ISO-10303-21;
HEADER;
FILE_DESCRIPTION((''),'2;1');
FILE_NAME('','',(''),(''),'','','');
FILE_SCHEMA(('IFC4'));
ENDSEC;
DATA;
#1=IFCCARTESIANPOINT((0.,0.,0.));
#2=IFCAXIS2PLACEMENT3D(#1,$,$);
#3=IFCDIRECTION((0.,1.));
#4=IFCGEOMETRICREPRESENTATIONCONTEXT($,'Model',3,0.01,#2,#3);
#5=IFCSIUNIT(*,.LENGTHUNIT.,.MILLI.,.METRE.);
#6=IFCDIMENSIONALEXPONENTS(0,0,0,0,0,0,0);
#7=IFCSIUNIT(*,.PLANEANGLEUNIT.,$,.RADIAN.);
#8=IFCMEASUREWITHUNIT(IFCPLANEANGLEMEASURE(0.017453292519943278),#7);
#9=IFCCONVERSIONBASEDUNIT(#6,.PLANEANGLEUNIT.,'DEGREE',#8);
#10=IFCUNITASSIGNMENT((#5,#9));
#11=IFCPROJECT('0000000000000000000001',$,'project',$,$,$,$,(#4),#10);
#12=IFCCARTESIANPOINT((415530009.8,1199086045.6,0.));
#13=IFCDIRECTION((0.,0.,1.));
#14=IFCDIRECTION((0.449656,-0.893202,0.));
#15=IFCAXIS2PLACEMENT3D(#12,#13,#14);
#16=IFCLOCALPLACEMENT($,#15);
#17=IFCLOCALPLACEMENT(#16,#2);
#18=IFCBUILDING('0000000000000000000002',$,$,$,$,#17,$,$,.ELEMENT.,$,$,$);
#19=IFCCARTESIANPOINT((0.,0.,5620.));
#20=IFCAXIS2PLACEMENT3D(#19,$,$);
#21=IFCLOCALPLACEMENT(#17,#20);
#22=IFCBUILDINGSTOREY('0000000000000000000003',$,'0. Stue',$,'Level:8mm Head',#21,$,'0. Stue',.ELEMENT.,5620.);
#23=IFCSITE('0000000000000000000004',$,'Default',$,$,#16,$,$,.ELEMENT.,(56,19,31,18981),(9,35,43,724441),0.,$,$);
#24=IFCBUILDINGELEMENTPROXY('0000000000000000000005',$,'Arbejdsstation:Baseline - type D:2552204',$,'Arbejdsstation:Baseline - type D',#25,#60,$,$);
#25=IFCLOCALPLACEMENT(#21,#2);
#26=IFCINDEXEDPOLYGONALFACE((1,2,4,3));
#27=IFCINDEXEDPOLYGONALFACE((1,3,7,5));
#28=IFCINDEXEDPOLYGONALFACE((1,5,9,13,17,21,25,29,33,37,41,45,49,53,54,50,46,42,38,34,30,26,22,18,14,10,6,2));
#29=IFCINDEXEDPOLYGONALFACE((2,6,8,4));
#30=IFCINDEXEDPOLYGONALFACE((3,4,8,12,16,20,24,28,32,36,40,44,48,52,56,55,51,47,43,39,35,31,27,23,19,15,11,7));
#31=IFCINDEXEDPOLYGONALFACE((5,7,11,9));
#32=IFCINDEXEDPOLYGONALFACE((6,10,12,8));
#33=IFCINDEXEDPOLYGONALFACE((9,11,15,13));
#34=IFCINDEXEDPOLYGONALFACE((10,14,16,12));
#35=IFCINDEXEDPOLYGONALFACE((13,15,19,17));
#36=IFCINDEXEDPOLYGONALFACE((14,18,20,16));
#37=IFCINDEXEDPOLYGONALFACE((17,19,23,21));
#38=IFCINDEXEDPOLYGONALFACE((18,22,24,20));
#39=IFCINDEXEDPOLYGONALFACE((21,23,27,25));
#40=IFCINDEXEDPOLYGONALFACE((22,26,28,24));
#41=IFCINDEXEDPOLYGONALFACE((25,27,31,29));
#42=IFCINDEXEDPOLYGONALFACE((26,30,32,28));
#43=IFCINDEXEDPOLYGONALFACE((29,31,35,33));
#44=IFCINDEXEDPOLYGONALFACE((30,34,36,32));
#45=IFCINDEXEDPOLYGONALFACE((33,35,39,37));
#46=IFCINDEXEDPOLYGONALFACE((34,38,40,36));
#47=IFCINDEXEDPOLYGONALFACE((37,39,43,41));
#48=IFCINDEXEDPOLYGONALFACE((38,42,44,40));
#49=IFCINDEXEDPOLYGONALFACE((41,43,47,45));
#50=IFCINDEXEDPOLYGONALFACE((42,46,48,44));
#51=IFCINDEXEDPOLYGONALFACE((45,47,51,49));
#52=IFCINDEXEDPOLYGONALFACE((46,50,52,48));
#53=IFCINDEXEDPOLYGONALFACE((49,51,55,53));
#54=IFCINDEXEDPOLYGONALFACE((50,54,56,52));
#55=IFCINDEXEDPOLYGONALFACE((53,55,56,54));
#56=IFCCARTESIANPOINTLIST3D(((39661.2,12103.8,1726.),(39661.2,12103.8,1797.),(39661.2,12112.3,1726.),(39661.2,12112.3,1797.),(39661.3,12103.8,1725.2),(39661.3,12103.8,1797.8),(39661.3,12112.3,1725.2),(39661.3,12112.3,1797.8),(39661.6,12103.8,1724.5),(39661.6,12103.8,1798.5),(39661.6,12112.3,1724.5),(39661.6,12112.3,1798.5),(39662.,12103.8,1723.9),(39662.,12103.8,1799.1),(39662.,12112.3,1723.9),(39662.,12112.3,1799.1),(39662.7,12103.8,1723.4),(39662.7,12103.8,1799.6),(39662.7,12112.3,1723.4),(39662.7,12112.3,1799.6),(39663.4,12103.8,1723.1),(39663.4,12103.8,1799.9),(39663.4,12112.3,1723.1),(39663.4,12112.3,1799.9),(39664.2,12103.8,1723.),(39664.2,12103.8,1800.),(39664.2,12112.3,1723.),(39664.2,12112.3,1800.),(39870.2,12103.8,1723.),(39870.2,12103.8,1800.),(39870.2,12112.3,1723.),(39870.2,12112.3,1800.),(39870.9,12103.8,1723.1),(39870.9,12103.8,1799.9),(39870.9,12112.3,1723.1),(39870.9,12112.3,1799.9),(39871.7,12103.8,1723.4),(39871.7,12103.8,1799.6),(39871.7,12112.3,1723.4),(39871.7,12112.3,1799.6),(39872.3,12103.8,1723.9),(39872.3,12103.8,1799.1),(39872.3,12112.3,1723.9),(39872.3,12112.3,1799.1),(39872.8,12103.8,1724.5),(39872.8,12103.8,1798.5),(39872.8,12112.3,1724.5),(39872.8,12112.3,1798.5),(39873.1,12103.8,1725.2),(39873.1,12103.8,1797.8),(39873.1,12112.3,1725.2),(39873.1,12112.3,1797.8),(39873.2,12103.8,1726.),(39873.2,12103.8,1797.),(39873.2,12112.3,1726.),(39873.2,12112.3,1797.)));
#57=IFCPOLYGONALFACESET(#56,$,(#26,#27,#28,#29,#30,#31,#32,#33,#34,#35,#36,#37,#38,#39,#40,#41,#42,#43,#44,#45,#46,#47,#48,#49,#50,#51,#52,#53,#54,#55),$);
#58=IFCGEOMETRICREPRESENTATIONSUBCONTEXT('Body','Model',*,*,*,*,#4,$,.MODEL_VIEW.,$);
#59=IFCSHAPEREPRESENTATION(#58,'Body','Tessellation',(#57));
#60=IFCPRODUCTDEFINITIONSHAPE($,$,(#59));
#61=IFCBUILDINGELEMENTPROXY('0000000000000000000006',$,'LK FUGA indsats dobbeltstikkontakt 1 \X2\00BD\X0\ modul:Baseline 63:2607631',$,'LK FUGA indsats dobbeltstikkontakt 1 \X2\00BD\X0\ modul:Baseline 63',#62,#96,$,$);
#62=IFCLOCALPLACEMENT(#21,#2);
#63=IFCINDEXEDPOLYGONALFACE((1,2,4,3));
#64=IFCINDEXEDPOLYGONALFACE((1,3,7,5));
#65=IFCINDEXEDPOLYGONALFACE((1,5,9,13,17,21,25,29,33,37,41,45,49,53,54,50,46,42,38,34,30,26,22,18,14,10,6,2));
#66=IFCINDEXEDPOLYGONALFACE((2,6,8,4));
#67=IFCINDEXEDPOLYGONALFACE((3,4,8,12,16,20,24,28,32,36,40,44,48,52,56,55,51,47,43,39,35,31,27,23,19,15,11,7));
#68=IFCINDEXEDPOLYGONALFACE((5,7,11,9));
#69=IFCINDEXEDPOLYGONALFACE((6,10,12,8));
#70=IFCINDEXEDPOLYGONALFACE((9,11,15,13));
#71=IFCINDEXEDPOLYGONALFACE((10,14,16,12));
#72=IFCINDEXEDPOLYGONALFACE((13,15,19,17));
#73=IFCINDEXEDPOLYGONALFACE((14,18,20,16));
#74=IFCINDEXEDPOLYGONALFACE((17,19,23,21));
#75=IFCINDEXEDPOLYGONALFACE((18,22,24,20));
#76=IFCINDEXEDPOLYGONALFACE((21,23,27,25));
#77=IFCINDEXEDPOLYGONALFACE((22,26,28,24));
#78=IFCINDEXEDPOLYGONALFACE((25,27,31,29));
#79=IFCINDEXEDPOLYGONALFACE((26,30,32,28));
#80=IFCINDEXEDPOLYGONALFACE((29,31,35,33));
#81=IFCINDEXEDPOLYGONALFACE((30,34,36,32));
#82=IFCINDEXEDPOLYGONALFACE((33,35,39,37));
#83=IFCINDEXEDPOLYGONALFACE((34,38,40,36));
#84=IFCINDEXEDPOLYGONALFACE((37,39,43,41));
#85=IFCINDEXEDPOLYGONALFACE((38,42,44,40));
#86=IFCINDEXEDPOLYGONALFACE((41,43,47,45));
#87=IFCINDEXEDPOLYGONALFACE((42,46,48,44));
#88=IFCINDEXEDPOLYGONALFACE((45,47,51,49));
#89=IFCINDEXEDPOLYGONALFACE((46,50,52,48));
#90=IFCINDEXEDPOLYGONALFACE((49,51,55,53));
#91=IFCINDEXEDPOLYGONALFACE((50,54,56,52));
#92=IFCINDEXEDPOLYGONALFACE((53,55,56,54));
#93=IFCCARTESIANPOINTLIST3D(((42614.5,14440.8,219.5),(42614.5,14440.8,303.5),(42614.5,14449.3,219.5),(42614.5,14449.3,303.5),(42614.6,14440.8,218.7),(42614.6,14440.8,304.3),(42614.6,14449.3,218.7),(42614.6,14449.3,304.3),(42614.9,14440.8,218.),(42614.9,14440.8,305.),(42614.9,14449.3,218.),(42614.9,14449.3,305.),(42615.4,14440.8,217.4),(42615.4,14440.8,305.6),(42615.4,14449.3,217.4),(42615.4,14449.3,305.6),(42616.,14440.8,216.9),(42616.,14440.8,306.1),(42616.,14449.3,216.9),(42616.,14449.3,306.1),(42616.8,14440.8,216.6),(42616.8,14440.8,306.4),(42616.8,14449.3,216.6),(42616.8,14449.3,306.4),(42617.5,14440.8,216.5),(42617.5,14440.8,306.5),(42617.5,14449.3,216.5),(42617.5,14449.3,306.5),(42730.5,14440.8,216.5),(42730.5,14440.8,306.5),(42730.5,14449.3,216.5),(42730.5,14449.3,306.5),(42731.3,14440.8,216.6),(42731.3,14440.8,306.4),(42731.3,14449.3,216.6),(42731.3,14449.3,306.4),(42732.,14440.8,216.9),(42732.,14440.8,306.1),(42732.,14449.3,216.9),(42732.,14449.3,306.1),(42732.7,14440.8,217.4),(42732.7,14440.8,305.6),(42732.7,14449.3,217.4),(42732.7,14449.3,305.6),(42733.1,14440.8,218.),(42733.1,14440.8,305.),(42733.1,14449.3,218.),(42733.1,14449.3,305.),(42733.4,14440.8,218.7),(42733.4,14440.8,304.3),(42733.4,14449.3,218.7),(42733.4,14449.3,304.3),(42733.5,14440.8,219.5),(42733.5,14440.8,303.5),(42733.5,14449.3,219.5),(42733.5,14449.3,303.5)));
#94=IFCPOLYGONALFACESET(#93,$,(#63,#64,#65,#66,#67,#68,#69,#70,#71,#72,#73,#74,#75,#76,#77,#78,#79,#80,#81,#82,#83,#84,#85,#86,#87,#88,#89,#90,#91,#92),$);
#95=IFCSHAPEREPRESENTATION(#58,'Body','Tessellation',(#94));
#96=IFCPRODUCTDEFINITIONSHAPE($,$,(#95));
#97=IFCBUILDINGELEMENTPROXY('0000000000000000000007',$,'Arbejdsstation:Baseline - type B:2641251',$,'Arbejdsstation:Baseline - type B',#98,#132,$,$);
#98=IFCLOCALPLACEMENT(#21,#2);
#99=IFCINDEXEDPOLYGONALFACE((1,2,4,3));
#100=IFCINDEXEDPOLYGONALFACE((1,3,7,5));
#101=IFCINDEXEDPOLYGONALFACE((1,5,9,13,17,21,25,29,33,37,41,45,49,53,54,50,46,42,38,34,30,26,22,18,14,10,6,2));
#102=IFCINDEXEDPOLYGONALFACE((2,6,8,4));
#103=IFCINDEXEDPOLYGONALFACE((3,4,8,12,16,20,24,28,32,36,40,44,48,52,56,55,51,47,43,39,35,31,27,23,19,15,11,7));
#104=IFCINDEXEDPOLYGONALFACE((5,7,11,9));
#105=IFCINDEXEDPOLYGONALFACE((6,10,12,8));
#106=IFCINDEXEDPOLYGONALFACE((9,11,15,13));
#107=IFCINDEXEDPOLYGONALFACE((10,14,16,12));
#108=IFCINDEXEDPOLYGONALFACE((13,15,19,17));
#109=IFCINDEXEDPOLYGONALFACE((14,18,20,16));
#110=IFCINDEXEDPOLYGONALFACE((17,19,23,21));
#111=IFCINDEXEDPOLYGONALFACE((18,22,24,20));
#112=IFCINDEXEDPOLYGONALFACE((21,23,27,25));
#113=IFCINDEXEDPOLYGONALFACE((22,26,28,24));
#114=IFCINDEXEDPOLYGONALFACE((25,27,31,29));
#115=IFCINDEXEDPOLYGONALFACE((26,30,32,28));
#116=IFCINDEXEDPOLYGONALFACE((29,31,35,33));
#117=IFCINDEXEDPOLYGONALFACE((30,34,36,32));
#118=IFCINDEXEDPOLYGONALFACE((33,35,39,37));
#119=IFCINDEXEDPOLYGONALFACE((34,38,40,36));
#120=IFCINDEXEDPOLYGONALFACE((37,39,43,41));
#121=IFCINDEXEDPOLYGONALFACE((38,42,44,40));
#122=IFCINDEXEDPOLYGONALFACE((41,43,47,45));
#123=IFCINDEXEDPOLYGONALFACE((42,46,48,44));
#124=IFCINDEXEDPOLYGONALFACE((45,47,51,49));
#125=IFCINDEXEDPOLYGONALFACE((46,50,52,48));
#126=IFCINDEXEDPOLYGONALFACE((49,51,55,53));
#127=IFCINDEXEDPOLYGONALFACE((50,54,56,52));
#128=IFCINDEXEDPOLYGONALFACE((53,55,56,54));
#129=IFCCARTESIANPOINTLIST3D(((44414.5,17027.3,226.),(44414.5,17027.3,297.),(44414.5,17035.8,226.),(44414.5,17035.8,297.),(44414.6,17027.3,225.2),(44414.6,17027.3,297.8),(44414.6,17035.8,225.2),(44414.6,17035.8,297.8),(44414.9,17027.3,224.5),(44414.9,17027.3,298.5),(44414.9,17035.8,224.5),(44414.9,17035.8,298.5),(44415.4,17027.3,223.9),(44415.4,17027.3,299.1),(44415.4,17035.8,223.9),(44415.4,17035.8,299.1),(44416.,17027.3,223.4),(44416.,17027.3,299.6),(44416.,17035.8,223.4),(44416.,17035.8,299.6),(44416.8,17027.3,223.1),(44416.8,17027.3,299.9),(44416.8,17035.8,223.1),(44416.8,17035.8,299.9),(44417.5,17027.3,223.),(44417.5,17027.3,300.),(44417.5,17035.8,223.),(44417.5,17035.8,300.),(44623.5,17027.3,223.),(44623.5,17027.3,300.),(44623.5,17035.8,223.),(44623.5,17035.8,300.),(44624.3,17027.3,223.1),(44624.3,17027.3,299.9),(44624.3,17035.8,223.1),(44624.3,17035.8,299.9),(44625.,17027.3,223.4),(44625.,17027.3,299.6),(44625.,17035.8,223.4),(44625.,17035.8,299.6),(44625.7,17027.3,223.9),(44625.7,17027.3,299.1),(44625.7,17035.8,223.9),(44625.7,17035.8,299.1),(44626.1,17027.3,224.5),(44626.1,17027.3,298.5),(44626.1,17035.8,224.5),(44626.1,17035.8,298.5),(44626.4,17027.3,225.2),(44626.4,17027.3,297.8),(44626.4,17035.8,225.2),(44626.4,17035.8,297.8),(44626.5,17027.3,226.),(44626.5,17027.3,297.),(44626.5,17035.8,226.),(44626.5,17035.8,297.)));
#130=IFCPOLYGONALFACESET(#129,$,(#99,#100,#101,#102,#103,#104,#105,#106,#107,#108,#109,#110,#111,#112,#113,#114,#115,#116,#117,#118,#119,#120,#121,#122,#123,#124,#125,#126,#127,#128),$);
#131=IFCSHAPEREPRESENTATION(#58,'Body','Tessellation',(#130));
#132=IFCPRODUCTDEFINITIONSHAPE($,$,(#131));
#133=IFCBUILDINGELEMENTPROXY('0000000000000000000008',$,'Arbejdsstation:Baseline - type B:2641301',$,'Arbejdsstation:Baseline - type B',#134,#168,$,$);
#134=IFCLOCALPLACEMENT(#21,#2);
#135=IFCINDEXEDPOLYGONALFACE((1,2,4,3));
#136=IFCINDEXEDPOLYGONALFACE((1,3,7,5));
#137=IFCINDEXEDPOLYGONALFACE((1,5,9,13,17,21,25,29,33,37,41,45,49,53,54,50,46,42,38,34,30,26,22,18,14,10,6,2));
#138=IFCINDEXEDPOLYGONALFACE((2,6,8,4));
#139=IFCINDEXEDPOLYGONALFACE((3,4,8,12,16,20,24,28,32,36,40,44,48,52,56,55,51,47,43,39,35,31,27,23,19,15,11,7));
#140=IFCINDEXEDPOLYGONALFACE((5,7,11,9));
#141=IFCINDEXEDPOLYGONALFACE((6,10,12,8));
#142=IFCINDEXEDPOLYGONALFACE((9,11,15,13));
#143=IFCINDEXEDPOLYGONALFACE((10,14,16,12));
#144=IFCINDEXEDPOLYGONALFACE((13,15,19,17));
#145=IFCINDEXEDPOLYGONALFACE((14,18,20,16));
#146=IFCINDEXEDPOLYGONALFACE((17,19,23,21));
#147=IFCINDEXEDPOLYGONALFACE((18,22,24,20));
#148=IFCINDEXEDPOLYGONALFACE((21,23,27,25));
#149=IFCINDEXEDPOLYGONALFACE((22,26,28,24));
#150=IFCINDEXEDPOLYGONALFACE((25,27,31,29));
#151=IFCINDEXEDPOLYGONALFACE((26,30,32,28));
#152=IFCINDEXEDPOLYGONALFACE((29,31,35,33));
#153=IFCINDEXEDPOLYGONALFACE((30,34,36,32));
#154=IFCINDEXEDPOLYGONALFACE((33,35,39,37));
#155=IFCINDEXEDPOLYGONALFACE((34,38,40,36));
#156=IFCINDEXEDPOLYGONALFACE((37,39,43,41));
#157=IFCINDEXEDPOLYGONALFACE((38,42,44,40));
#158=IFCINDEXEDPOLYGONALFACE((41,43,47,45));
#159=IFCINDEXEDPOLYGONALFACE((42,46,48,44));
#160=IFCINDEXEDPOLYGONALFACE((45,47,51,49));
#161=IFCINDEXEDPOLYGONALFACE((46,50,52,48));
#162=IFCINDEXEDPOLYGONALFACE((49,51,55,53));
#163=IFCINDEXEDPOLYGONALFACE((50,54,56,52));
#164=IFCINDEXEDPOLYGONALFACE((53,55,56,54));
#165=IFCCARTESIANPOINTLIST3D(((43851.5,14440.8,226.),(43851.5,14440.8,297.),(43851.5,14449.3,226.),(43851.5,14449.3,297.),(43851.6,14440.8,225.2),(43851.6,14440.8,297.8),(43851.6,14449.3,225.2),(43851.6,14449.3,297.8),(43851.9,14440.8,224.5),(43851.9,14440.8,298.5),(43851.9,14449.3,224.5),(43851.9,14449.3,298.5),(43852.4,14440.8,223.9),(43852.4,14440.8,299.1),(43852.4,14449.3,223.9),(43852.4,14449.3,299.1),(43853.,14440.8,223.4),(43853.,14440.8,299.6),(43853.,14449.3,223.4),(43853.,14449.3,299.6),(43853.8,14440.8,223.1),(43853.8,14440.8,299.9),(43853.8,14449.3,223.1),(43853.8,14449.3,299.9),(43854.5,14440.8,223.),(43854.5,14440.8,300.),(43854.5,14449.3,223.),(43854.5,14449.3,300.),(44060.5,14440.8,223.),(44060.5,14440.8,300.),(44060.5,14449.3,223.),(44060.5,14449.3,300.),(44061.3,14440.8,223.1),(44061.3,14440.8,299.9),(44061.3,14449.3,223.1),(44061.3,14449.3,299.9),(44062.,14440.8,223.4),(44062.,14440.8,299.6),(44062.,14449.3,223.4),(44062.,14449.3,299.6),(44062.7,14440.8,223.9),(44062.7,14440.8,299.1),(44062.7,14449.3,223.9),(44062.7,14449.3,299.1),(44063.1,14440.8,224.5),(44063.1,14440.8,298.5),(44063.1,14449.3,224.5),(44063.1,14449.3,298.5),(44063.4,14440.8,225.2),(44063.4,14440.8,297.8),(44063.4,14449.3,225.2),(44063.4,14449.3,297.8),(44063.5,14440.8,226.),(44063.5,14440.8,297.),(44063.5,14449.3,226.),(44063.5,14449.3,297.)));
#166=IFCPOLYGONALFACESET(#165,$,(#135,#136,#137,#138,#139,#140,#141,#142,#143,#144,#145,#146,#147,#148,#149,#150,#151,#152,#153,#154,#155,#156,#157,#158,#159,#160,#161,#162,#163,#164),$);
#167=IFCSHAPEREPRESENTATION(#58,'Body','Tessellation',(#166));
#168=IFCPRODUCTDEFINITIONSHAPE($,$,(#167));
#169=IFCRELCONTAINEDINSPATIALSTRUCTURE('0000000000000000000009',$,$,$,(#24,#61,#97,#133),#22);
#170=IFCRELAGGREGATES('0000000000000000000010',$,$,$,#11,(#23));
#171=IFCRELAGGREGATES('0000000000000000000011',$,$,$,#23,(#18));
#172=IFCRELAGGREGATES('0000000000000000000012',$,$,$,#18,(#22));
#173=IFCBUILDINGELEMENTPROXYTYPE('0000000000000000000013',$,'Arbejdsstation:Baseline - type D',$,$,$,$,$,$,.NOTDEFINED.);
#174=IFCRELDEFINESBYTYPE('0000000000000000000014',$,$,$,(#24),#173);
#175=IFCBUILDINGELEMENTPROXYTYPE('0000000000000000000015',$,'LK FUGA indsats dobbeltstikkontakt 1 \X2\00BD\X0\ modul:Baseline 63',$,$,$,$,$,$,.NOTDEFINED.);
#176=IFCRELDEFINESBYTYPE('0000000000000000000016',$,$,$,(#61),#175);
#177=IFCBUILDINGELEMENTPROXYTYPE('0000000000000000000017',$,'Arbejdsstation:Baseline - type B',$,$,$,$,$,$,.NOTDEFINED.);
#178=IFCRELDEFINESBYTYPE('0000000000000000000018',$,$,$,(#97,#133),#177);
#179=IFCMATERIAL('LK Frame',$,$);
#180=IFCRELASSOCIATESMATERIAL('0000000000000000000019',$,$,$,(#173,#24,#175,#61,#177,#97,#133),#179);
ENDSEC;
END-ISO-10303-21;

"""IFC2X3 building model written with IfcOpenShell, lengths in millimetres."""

from ifc_helpers import new_model, entity, si_unit, converted_unit, direction, frame, frame_2d, origin, place, context, subcontext, project, spatial, polyline, circle_curve, parameter, trimmed, segment, composite_curve, outline, extrude, source, transform, mapped, material, type_object, type_shapes, element, save


model = new_model("IFC2X3")

# Units and contexts
model_context = context("Model", 3, precision=0.01, world=origin(), true_north=direction((0.0, 1.0)))
body_context = subcontext(model_context, "Body", "Model", "MODEL_VIEW")
ifc_project = project(units=[si_unit("LENGTHUNIT", "METRE", prefix="MILLI"), converted_unit("PLANEANGLEUNIT", "DEGREE", entity("IfcPlaneAngleMeasure", 0.017453292519943278), si_unit("PLANEANGLEUNIT", "RADIAN"), dimensions=[0, 0, 0, 0, 0, 0, 0])], contexts=[model_context])

# Site, building, storey
site_placement = place(None, frame((415530009.8, 1199086045.6, 0.0), z_axis=(0.0, 0.0, 1.0), x_axis=(0.449656, -0.893202, 0.0)))
site = spatial("IfcSite", under=ifc_project, at=site_placement, Name="Default", CompositionType="ELEMENT", RefLatitude=(56, 19, 31, 18981), RefLongitude=(9, 35, 43, 724441), RefElevation=0.0)
building_placement = place(site_placement, origin())
building = spatial("IfcBuilding", under=site, at=building_placement, CompositionType="ELEMENT")
storey_placement = place(building_placement, frame((0.0, 0.0, 5620.0)))
storey = spatial("IfcBuildingStorey", under=building, at=storey_placement, Name="0. Stue", ObjectType="Level:8mm Head", LongName="0. Stue", CompositionType="ELEMENT", Elevation=5620.0)

# Building element proxies
ifc_material_1 = material(Name="LK Frame")
building_element_proxy_type_1 = type_object("IfcBuildingElementProxyType", Name="Arbejdsstation:Baseline - type D", PredefinedType="NOTDEFINED", material=ifc_material_1)
shared_shape_1 = source(origin(), body_context, "Body", "SweptSolid", [
    extrude(outline(composite_curve([segment(polyline([(-35.5, -106.0), (35.5, -106.0)]), True, "CONTINUOUS"), segment(trimmed(circle_curve(frame_2d((35.5, -103.0), x_axis=(-1.0, 0.0)), 3.0), [parameter(90.0)], [parameter(180.0)], True, "PARAMETER"), True, "CONTINUOUS"), segment(polyline([(38.5, -103.0), (38.5, 103.0)]), True, "CONTINUOUS"), segment(trimmed(circle_curve(frame_2d((35.5, 103.0), x_axis=(-1.0, 0.0)), 3.0), [parameter(180.0)], [parameter(270.0)], True, "PARAMETER"), True, "CONTINUOUS"), segment(polyline([(35.5, 106.0), (-35.5, 106.0)]), True, "CONTINUOUS"), segment(trimmed(circle_curve(frame_2d((-35.5, 103.0), x_axis=(1.0, 0.0)), 3.0), [parameter(90.0)], [parameter(180.0)], True, "PARAMETER"), True, "CONTINUOUS"), segment(polyline([(-38.5, 103.0), (-38.5, -103.0)]), True, "CONTINUOUS"), segment(trimmed(circle_curve(frame_2d((-35.5, -103.0), x_axis=(1.0, 0.0)), 3.0), [parameter(180.0)], [parameter(270.0)], True, "PARAMETER"), True, "CONTINUOUS")], self_intersect=False)), frame((-3.5, -38.5, 0.0), z_axis=(0.0, 0.0, 1.0), x_axis=(0.0, 1.0, 0.0)), (0.0, 0.0, 1.0), 8.5),
])
type_shapes(building_element_proxy_type_1, [shared_shape_1])
proxy_1_placement = place(storey_placement, frame((39763.7, 12103.8, 1800.0), z_axis=(0.0, 1.0, 0.0), x_axis=(-1.0, 0.0, 0.0)))
element("IfcBuildingElementProxy", 1, at=proxy_1_placement, inside=storey, type_object=building_element_proxy_type_1, material=ifc_material_1, Name="Arbejdsstation:Baseline - type D:2552204", ObjectType="Arbejdsstation:Baseline - type D", context=body_context, shape_type="MappedRepresentation", body=[
    mapped(shared_shape_1, transform((0.0, 0.0, 0.0), scale=1.0)),
])
building_element_proxy_type_2 = type_object("IfcBuildingElementProxyType", Name="LK FUGA indsats dobbeltstikkontakt 1 ½ modul:Baseline 63", PredefinedType="NOTDEFINED", material=ifc_material_1)
shared_shape_2 = source(origin(), body_context, "Body", "SweptSolid", [
    extrude(outline(composite_curve([segment(polyline([(-42.0, -59.5), (42.0, -59.5)]), True, "CONTINUOUS"), segment(trimmed(circle_curve(frame_2d((42.0, -56.5), x_axis=(-1.0, 0.0)), 3.0), [parameter(90.0)], [parameter(180.0)], True, "PARAMETER"), True, "CONTINUOUS"), segment(polyline([(45.0, -56.5), (45.0, 56.5)]), True, "CONTINUOUS"), segment(trimmed(circle_curve(frame_2d((42.0, 56.5), x_axis=(-1.0, 0.0)), 3.0), [parameter(180.0)], [parameter(270.0)], True, "PARAMETER"), True, "CONTINUOUS"), segment(polyline([(42.0, 59.5), (-42.0, 59.5)]), True, "CONTINUOUS"), segment(trimmed(circle_curve(frame_2d((-42.0, 56.5), x_axis=(1.0, 0.0)), 3.0), [parameter(90.0)], [parameter(180.0)], True, "PARAMETER"), True, "CONTINUOUS"), segment(polyline([(-45.0, 56.5), (-45.0, -56.5)]), True, "CONTINUOUS"), segment(trimmed(circle_curve(frame_2d((-42.0, -56.5), x_axis=(1.0, 0.0)), 3.0), [parameter(180.0)], [parameter(270.0)], True, "PARAMETER"), True, "CONTINUOUS")], self_intersect=False)), frame((0.0, -38.5, 0.0), z_axis=(0.0, 0.0, 1.0), x_axis=(0.0, 1.0, 0.0)), (0.0, 0.0, 1.0), 8.5),
])
type_shapes(building_element_proxy_type_2, [shared_shape_2])
proxy_2_placement = place(storey_placement, frame((42674.0, 14440.8, 300.0), z_axis=(0.0, 1.0, 0.0), x_axis=(-1.0, 0.0, 0.0)))
element("IfcBuildingElementProxy", 2, at=proxy_2_placement, inside=storey, type_object=building_element_proxy_type_2, material=ifc_material_1, Name="LK FUGA indsats dobbeltstikkontakt 1 ½ modul:Baseline 63:2607631", ObjectType="LK FUGA indsats dobbeltstikkontakt 1 ½ modul:Baseline 63", context=body_context, shape_type="MappedRepresentation", body=[
    mapped(shared_shape_2, transform((0.0, 0.0, 0.0), scale=1.0)),
])
building_element_proxy_type_3 = type_object("IfcBuildingElementProxyType", Name="Arbejdsstation:Baseline - type B", PredefinedType="NOTDEFINED", material=ifc_material_1)
shared_shape_3 = source(origin(), body_context, "Body", "SweptSolid", [
    extrude(outline(composite_curve([segment(polyline([(-35.5, -106.0), (35.5, -106.0)]), True, "CONTINUOUS"), segment(trimmed(circle_curve(frame_2d((35.5, -103.0), x_axis=(-1.0, 0.0)), 3.0), [parameter(90.0)], [parameter(180.0)], True, "PARAMETER"), True, "CONTINUOUS"), segment(polyline([(38.5, -103.0), (38.5, 103.0)]), True, "CONTINUOUS"), segment(trimmed(circle_curve(frame_2d((35.5, 103.0), x_axis=(-1.0, 0.0)), 3.0), [parameter(180.0)], [parameter(270.0)], True, "PARAMETER"), True, "CONTINUOUS"), segment(polyline([(35.5, 106.0), (-35.5, 106.0)]), True, "CONTINUOUS"), segment(trimmed(circle_curve(frame_2d((-35.5, 103.0), x_axis=(1.0, 0.0)), 3.0), [parameter(90.0)], [parameter(180.0)], True, "PARAMETER"), True, "CONTINUOUS"), segment(polyline([(-38.5, 103.0), (-38.5, -103.0)]), True, "CONTINUOUS"), segment(trimmed(circle_curve(frame_2d((-35.5, -103.0), x_axis=(1.0, 0.0)), 3.0), [parameter(180.0)], [parameter(270.0)], True, "PARAMETER"), True, "CONTINUOUS")], self_intersect=False)), frame((-3.5, -38.5, 0.0), z_axis=(0.0, 0.0, 1.0), x_axis=(0.0, 1.0, 0.0)), (0.0, 0.0, 1.0), 8.5),
])
type_shapes(building_element_proxy_type_3, [shared_shape_3])
for number, where, z_axis, x_axis, name in (
    (3, (44524.0, 17035.8, 300.0), (0.0, -1.0, 0.0), (1.0, 0.0, 0.0), "Arbejdsstation:Baseline - type B:2641251"),
    (4, (43954.0, 14440.8, 300.0), (0.0, 1.0, 0.0), (-1.0, 0.0, 0.0), "Arbejdsstation:Baseline - type B:2641301"),
):
    element("IfcBuildingElementProxy", number, at=place(storey_placement, frame(where, z_axis=z_axis, x_axis=x_axis)), inside=storey, type_object=building_element_proxy_type_3, material=ifc_material_1, Name=name, ObjectType="Arbejdsstation:Baseline - type B", context=body_context, shape_type="MappedRepresentation", body=[
        mapped(shared_shape_3, transform((0.0, 0.0, 0.0), scale=1.0)),
    ])

save(model, "model.ifc")
